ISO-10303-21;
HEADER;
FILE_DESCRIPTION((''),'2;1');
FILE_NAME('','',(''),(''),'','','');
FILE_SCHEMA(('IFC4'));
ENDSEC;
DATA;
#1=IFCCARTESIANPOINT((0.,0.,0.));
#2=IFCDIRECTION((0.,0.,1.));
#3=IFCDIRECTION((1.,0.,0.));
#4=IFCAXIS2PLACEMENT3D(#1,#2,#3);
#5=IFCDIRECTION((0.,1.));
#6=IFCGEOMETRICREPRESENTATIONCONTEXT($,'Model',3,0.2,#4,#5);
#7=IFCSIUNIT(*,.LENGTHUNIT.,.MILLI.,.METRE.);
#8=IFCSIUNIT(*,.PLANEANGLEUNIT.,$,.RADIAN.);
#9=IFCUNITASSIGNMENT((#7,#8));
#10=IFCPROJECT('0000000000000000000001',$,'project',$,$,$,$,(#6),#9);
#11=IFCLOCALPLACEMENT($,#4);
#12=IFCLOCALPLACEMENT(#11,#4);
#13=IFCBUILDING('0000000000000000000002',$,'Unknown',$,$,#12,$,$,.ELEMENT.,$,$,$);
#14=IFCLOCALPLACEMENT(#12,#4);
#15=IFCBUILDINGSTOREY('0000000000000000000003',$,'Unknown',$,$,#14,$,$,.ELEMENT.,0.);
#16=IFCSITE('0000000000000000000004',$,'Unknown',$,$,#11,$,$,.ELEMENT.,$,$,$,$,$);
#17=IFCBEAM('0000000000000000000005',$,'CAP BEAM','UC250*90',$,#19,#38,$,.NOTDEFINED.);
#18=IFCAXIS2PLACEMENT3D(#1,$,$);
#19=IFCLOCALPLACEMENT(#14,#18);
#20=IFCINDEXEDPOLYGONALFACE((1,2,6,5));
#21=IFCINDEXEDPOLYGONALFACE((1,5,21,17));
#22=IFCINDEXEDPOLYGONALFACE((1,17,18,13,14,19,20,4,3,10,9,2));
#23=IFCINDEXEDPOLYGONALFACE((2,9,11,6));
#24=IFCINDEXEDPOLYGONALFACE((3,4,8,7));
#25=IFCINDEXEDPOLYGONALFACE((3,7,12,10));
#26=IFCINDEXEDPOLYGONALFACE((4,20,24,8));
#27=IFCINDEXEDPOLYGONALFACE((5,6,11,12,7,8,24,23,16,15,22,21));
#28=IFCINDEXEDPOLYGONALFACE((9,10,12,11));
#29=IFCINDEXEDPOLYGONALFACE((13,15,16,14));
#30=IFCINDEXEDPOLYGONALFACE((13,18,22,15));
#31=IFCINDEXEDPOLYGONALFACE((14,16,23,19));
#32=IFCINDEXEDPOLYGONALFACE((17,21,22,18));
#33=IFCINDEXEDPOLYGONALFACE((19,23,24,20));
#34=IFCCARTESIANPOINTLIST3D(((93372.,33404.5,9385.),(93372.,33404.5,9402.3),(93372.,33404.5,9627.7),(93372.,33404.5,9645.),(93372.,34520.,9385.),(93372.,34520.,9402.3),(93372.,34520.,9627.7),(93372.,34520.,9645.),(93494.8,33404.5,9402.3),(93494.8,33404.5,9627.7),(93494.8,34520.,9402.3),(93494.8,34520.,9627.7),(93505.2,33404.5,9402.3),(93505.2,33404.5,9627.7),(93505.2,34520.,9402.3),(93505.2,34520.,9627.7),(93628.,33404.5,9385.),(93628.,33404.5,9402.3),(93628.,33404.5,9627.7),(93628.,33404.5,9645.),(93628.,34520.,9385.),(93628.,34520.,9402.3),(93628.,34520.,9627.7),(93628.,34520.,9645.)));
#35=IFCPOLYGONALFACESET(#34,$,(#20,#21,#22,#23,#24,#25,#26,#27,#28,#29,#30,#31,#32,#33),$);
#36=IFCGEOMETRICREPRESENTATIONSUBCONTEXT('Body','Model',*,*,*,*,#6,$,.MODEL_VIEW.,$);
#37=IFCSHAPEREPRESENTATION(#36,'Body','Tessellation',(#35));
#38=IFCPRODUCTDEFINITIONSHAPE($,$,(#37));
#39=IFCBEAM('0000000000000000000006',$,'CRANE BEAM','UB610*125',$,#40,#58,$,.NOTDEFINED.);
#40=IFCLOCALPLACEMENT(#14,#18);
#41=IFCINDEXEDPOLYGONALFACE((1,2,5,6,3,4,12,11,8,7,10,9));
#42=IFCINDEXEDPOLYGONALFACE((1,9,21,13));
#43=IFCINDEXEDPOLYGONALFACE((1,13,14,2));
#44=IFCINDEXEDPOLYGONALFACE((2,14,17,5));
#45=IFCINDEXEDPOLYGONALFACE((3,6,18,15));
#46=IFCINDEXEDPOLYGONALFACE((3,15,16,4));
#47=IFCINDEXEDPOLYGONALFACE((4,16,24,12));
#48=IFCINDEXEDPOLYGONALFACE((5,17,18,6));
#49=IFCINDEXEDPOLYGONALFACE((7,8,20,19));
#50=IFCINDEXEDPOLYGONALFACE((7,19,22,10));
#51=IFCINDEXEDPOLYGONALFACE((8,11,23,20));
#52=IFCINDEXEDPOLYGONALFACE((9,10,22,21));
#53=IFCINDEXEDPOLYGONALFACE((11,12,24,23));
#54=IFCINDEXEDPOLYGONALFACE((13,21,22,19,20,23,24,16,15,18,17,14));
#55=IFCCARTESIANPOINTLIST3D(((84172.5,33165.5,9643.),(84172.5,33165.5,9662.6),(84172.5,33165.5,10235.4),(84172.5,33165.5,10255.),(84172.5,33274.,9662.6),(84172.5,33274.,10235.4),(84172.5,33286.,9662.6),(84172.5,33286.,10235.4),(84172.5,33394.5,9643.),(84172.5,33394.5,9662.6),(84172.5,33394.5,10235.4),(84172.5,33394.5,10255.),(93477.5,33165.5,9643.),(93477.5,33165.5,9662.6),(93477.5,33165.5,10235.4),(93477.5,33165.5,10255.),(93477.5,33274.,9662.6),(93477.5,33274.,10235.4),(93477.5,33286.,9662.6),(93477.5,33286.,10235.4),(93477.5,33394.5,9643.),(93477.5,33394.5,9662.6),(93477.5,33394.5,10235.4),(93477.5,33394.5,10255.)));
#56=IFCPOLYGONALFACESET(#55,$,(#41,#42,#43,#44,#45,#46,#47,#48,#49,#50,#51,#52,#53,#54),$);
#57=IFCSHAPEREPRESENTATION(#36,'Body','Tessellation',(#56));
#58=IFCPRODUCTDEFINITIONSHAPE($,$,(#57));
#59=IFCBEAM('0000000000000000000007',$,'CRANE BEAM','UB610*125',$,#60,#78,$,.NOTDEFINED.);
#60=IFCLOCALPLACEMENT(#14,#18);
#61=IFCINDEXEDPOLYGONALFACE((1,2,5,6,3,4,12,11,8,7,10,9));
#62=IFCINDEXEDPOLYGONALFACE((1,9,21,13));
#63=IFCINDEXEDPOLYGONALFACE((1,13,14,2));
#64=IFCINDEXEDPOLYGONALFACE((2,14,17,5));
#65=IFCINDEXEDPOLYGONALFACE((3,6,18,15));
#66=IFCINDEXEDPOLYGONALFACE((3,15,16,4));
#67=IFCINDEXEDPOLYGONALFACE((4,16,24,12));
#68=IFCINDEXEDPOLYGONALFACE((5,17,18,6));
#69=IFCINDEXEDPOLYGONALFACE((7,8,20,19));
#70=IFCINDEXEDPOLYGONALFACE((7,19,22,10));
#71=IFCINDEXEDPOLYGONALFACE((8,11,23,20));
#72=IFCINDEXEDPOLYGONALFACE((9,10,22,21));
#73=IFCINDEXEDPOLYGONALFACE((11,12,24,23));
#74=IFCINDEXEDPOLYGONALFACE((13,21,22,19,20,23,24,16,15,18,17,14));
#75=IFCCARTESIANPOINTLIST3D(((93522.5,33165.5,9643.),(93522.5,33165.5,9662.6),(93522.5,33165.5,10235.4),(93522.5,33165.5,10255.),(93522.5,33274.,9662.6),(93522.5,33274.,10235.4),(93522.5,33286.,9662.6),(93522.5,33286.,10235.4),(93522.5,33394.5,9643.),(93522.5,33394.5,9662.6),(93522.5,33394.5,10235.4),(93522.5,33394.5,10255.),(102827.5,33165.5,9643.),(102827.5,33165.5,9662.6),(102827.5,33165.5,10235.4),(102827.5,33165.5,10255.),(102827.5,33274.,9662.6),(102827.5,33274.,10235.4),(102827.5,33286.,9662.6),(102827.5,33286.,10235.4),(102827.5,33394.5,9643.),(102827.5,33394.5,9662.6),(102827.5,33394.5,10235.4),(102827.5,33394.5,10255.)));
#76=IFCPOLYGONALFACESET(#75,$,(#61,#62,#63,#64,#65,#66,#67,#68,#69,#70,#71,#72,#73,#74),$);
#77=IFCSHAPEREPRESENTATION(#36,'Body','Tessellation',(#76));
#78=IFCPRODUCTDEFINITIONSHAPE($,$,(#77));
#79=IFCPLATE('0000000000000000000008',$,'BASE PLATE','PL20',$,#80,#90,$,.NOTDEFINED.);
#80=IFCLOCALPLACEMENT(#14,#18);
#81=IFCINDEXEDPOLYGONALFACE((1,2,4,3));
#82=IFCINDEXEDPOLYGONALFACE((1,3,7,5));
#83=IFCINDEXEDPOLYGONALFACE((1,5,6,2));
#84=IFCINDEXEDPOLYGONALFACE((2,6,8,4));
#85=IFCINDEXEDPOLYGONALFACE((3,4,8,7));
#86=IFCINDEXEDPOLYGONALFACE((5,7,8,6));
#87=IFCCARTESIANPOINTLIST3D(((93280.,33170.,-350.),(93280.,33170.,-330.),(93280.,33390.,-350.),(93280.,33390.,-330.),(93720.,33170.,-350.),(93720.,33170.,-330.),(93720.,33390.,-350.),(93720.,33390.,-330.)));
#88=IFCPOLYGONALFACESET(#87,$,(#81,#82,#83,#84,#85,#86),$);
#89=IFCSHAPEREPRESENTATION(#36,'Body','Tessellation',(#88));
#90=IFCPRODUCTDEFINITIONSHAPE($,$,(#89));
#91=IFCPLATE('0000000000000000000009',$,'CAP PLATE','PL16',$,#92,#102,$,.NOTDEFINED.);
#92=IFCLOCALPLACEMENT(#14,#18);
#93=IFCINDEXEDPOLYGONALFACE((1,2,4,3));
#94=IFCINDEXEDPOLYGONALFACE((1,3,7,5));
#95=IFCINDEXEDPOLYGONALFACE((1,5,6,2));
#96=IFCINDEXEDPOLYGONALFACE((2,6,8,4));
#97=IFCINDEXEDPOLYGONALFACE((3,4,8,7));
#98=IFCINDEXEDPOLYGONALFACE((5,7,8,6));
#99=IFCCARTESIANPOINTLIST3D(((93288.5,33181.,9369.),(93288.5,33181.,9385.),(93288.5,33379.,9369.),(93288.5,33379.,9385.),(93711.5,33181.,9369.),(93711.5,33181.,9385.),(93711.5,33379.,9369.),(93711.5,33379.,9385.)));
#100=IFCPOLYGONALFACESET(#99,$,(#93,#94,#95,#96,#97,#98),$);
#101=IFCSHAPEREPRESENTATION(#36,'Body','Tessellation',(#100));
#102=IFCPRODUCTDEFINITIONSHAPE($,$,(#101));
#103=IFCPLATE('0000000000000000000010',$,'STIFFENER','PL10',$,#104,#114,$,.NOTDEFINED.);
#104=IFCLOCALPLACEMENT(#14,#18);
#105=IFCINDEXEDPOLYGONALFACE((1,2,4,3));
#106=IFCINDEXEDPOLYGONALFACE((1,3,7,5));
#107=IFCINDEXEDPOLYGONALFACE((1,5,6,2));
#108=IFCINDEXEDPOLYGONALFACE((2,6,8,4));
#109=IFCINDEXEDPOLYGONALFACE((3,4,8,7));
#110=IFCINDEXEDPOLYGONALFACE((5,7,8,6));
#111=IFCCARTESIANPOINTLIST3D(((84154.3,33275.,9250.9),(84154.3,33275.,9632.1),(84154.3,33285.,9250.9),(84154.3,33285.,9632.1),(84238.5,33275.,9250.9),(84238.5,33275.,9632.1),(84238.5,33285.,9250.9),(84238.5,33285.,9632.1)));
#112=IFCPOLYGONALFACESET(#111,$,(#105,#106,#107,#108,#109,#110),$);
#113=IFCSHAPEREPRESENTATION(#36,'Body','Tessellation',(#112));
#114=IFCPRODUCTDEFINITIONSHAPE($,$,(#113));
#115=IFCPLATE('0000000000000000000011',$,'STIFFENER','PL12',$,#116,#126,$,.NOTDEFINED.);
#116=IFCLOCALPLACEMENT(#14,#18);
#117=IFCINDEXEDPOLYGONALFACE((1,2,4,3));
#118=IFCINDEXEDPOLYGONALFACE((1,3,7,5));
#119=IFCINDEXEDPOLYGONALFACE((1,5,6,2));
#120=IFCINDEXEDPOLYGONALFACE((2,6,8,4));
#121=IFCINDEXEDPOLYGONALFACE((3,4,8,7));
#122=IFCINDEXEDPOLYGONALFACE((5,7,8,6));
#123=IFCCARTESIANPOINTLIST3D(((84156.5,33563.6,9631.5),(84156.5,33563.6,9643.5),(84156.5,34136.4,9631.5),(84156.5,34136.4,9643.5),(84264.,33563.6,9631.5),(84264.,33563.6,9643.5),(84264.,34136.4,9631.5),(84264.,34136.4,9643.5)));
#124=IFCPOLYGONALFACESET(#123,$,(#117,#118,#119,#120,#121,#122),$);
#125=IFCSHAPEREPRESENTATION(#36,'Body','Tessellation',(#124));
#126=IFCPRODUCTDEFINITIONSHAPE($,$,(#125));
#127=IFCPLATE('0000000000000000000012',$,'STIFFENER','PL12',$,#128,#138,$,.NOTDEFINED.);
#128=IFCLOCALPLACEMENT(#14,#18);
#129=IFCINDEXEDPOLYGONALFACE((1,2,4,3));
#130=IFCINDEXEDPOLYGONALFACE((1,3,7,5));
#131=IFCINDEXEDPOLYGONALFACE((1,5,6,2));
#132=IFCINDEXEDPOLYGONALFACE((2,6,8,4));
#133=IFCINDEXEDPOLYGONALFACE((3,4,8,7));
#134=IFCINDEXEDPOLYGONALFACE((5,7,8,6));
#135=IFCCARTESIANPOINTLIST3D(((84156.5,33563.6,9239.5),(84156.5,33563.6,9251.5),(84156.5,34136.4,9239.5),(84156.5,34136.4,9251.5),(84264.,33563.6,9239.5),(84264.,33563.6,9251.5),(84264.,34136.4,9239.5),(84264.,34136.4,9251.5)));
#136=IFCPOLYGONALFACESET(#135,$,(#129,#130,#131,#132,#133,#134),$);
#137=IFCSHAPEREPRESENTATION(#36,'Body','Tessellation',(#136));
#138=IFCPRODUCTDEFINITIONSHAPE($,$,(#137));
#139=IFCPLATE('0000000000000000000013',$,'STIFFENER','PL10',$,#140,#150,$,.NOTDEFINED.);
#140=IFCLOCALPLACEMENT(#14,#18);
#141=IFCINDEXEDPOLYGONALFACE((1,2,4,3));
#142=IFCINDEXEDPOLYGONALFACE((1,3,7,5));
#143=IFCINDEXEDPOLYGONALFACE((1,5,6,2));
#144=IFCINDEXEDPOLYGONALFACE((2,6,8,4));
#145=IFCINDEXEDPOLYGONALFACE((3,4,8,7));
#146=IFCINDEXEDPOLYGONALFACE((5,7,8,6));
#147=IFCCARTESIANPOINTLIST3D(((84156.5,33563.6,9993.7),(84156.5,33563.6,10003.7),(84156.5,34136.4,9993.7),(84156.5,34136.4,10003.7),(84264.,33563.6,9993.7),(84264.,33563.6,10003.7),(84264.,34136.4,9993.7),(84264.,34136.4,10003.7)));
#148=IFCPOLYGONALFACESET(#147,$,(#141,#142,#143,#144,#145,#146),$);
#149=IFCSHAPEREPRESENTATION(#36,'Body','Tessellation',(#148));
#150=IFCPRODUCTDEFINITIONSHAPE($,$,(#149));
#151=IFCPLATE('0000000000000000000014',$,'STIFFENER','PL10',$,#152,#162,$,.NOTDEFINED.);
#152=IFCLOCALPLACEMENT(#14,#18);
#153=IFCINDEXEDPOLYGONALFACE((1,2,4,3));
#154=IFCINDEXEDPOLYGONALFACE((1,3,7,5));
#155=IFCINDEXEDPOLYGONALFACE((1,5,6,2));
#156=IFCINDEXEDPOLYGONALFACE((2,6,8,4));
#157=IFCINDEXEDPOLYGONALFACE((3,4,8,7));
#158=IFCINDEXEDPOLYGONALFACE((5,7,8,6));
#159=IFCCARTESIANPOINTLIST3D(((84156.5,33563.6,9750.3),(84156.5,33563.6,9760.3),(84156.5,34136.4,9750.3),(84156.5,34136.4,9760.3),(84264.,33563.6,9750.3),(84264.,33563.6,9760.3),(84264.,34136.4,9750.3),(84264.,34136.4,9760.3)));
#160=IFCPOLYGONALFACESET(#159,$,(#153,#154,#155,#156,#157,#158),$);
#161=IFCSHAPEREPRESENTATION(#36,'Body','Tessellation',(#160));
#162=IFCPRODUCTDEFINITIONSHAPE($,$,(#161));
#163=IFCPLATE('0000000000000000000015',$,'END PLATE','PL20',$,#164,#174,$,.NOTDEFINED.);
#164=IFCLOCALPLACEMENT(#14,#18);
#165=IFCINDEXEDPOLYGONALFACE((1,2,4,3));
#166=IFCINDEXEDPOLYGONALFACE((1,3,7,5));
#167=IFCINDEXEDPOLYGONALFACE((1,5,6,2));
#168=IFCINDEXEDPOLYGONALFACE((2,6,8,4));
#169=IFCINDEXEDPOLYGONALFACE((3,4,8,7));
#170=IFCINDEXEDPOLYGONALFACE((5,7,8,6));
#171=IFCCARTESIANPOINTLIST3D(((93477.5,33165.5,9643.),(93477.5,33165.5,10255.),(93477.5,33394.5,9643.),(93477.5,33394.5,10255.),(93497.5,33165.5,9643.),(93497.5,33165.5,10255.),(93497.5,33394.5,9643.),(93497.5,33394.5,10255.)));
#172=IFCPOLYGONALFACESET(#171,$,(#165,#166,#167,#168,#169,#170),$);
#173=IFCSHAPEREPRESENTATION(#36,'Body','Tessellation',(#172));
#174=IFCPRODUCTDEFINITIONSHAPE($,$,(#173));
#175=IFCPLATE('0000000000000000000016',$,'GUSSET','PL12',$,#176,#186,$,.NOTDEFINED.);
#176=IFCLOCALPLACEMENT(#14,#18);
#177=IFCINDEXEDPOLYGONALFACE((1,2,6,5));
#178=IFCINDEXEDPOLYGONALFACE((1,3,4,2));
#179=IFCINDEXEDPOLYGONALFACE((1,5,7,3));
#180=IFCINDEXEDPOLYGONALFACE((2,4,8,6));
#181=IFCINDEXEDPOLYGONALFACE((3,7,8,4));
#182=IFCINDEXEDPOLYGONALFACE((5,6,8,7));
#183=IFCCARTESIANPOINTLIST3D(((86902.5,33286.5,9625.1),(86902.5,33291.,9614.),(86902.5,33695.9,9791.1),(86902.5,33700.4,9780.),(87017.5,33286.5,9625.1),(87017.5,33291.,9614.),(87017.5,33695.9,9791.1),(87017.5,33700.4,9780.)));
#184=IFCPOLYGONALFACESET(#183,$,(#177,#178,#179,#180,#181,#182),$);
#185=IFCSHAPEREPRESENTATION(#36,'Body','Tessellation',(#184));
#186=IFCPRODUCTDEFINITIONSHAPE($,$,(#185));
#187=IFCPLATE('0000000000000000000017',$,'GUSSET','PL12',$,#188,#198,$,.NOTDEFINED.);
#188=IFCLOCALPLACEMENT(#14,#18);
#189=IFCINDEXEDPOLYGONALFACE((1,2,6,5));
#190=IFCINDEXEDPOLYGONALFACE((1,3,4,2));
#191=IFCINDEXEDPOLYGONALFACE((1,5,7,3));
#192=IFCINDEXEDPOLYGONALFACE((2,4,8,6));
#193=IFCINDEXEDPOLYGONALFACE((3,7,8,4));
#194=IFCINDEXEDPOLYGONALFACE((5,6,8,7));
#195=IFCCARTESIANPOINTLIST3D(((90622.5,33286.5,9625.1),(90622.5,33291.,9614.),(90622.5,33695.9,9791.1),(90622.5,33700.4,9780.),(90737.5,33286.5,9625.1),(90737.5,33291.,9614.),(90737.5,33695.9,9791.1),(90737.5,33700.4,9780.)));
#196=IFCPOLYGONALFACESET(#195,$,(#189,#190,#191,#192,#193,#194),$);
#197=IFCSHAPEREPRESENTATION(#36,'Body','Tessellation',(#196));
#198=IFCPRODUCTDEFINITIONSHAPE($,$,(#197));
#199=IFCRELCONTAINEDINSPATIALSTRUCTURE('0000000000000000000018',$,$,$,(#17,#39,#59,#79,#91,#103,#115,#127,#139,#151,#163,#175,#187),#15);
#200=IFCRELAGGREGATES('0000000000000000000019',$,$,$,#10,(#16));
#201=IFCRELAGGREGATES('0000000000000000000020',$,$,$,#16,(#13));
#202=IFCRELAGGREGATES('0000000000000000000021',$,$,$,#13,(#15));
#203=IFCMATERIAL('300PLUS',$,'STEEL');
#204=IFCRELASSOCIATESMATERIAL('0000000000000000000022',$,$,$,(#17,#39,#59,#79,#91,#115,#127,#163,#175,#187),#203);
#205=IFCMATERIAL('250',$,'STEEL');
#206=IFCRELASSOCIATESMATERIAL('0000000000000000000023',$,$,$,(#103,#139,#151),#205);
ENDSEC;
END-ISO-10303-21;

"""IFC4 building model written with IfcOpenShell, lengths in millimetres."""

from ifc_helpers import new_model, si_unit, direction, frame, origin_with_axes, place, context, subcontext, project, spatial, line, indexed_curve, outline, extrude, material, element, save


model = new_model("IFC4")

# Units and contexts
model_context = context("Model", 3, precision=0.2, world=origin_with_axes(), true_north=direction((0.0, 1.0)))
body_context = subcontext(model_context, "Body", "Model", "MODEL_VIEW")
ifc_project = project(units=[si_unit("LENGTHUNIT", "METRE", prefix="MILLI"), si_unit("PLANEANGLEUNIT", "RADIAN")], contexts=[model_context])

# Site, building, storey
site_placement = place(None, origin_with_axes())
site = spatial("IfcSite", under=ifc_project, at=site_placement, Name="Unknown", CompositionType="ELEMENT")
building_placement = place(site_placement, origin_with_axes())
building = spatial("IfcBuilding", under=site, at=building_placement, Name="Unknown", CompositionType="ELEMENT")
storey_placement = place(building_placement, origin_with_axes())
storey = spatial("IfcBuildingStorey", under=building, at=storey_placement, Name="Unknown", CompositionType="ELEMENT", Elevation=0.0)

# Shared definitions
ifc_material_1 = material(Name="300PLUS", Category="STEEL")

# Beams
beam_1_placement = place(storey_placement, frame((93500.0, 33404.5, 9515.0), z_axis=(1.0, 0.0, 0.0), x_axis=(0.0, 1.0, 0.0)))
element("IfcBeam", 1, at=beam_1_placement, inside=storey, material=ifc_material_1, Name="CAP BEAM", Description="UC250*90", PredefinedType="NOTDEFINED", context=body_context, shape_type="SolidModel", body=[
    extrude(outline(indexed_curve([(-128.0, -130.0), (128.0, -130.0), (128.0, -112.7), (5.2, -112.7), (5.2, 112.7), (128.0, 112.7), (128.0, 130.0), (-128.0, 130.0), (-128.0, 112.7), (-5.2, 112.7), (-5.2, -112.7), (-128.0, -112.7)], segments=[line(1, 2, 3, 4, 5, 6, 7, 8, 9, 10, 11, 12, 1)])), frame((0.0, 0.0, 0.0), z_axis=(-1.0, 0.0, 0.0), x_axis=(0.0, 0.0, 1.0)), (0.0, 0.0, -1.0), 1115.5),
])
for number, where, z_axis, x_axis, name in (
    (2, (84172.5, 33280.0, 9949.0), (0.0, -1.0, 0.0), (1.0, 0.0, 0.0), "CRANE BEAM"),
    (3, (93522.5, 33280.0, 9949.0), (0.0, -1.0, 0.0), (1.0, 0.0, 0.0), "CRANE BEAM"),
):
    element("IfcBeam", number, at=place(storey_placement, frame(where, z_axis=z_axis, x_axis=x_axis)), inside=storey, material=ifc_material_1, Name=name, Description="UB610*125", PredefinedType="NOTDEFINED", context=body_context, shape_type="SolidModel", body=[
        extrude(outline(indexed_curve([(-114.5, -306.0), (114.5, -306.0), (114.5, -286.4), (6.0, -286.4), (6.0, 286.4), (114.5, 286.4), (114.5, 306.0), (-114.5, 306.0), (-114.5, 286.4), (-6.0, 286.4), (-6.0, -286.4), (-114.5, -286.4)], segments=[line(1, 2, 3, 4, 5, 6, 7, 8, 9, 10, 11, 12, 1)])), frame((0.0, 0.0, 0.0), z_axis=(-1.0, 0.0, 0.0), x_axis=(0.0, 0.0, 1.0)), (0.0, 0.0, -1.0), 9305.0),
    ])

# Plates
plate_1_placement = place(storey_placement, frame((93280.0, 33170.0, -340.0), z_axis=(0.0, 0.0, 1.0), x_axis=(1.0, 0.0, 0.0)))
element("IfcPlate", 4, at=plate_1_placement, inside=storey, material=ifc_material_1, Name="BASE PLATE", Description="PL20", PredefinedType="NOTDEFINED", context=body_context, shape_type="SolidModel", body=[
    extrude(outline(indexed_curve([(0.0, 0.0), (440.0, 0.0), (440.0, 220.0), (0.0, 220.0)], segments=[line(1, 2, 3, 4, 1)])), frame((0.0, 0.0, 10.0), z_axis=(0.0, 0.0, 1.0), x_axis=(1.0, 0.0, 0.0)), (0.0, 0.0, -1.0), 20.0),
])
plate_2_placement = place(storey_placement, frame((93288.5, 33181.0, 9377.0), z_axis=(0.0, 0.0, 1.0), x_axis=(1.0, 0.0, 0.0)))
element("IfcPlate", 5, at=plate_2_placement, inside=storey, material=ifc_material_1, Name="CAP PLATE", Description="PL16", PredefinedType="NOTDEFINED", context=body_context, shape_type="SolidModel", body=[
    extrude(outline(indexed_curve([(0.0, 0.0), (423.0, 0.0), (423.0, 198.0), (0.0, 198.0)], segments=[line(1, 2, 3, 4, 1)])), frame((0.0, 0.0, 8.0), z_axis=(0.0, 0.0, 1.0), x_axis=(1.0, 0.0, 0.0)), (0.0, 0.0, -1.0), 16.0),
])
ifc_material_2 = material(Name="250", Category="STEEL")
plate_3_placement = place(storey_placement, frame((84238.5, 33280.0, 9632.1), z_axis=(0.0, -1.0, 0.0), x_axis=(-1.0, 0.0, 0.0)))
element("IfcPlate", 6, at=plate_3_placement, inside=storey, material=ifc_material_2, Name="STIFFENER", Description="PL10", PredefinedType="NOTDEFINED", context=body_context, shape_type="SolidModel", body=[
    extrude(outline(indexed_curve([(0.0, 0.0), (84.2, 0.0), (84.2, 381.2), (0.0, 381.2)], segments=[line(1, 2, 3, 4, 1)])), frame((0.0, 0.0, 5.0), z_axis=(0.0, 0.0, 1.0), x_axis=(1.0, 0.0, 0.0)), (0.0, 0.0, -1.0), 10.0),
])
for number, where, z_axis, x_axis, name in (
    (7, (84264.0, 33563.6, 9637.5), (0.0, 0.0, 1.0), (0.0, 1.0, 0.0), "STIFFENER"),
    (8, (84264.0, 33563.6, 9245.5), (0.0, 0.0, 1.0), (0.0, 1.0, 0.0), "STIFFENER"),
):
    element("IfcPlate", number, at=place(storey_placement, frame(where, z_axis=z_axis, x_axis=x_axis)), inside=storey, material=ifc_material_1, Name=name, Description="PL12", PredefinedType="NOTDEFINED", context=body_context, shape_type="SolidModel", body=[
        extrude(outline(indexed_curve([(0.0, 0.0), (572.8, 0.0), (572.8, 107.5), (0.0, 107.5)], segments=[line(1, 2, 3, 4, 1)])), frame((0.0, 0.0, 6.0), z_axis=(0.0, 0.0, 1.0), x_axis=(1.0, 0.0, 0.0)), (0.0, 0.0, -1.0), 12.0),
    ])
for number, where, z_axis, x_axis, name in (
    (9, (84264.0, 33563.6, 9998.7), (0.0, 0.0, 1.0), (0.0, 1.0, 0.0), "STIFFENER"),
    (10, (84264.0, 33563.6, 9755.3), (0.0, 0.0, 1.0), (0.0, 1.0, 0.0), "STIFFENER"),
):
    element("IfcPlate", number, at=place(storey_placement, frame(where, z_axis=z_axis, x_axis=x_axis)), inside=storey, material=ifc_material_2, Name=name, Description="PL10", PredefinedType="NOTDEFINED", context=body_context, shape_type="SolidModel", body=[
        extrude(outline(indexed_curve([(0.0, 0.0), (572.8, 0.0), (572.8, 107.5), (0.0, 107.5)], segments=[line(1, 2, 3, 4, 1)])), frame((0.0, 0.0, 5.0), z_axis=(0.0, 0.0, 1.0), x_axis=(1.0, 0.0, 0.0)), (0.0, 0.0, -1.0), 10.0),
    ])
plate_4_placement = place(storey_placement, frame((93487.5, 33394.5, 9643.0), z_axis=(-1.0, 0.0, 0.0), x_axis=(0.0, -1.0, 0.0)))
element("IfcPlate", 11, at=plate_4_placement, inside=storey, material=ifc_material_1, Name="END PLATE", Description="PL20", PredefinedType="NOTDEFINED", context=body_context, shape_type="SolidModel", body=[
    extrude(outline(indexed_curve([(0.0, 0.0), (229.0, 0.0), (229.0, 612.0), (0.0, 612.0)], segments=[line(1, 2, 3, 4, 1)])), frame((0.0, 0.0, 10.0), z_axis=(0.0, 0.0, 1.0), x_axis=(1.0, 0.0, 0.0)), (0.0, 0.0, -1.0), 20.0),
])
for number, where, z_axis, x_axis, name in (
    (12, (87017.5, 33288.7, 9619.6), (0.0, -0.375758, 0.926718), (0.0, 0.926718, 0.375758), "GUSSET"),
    (13, (90737.5, 33288.7, 9619.6), (0.0, -0.375758, 0.926718), (0.0, 0.926718, 0.375758), "GUSSET"),
):
    element("IfcPlate", number, at=place(storey_placement, frame(where, z_axis=z_axis, x_axis=x_axis)), inside=storey, material=ifc_material_1, Name=name, Description="PL12", PredefinedType="NOTDEFINED", context=body_context, shape_type="SolidModel", body=[
        extrude(outline(indexed_curve([(0.0, 0.0), (441.8, 0.0), (441.8, 115.0), (0.0, 115.0)], segments=[line(1, 2, 3, 4, 1)])), frame((0.0, 0.0, 6.0), z_axis=(0.0, 0.0, 1.0), x_axis=(1.0, 0.0, 0.0)), (0.0, 0.0, -1.0), 12.0),
    ])

save(model, "model.ifc")
